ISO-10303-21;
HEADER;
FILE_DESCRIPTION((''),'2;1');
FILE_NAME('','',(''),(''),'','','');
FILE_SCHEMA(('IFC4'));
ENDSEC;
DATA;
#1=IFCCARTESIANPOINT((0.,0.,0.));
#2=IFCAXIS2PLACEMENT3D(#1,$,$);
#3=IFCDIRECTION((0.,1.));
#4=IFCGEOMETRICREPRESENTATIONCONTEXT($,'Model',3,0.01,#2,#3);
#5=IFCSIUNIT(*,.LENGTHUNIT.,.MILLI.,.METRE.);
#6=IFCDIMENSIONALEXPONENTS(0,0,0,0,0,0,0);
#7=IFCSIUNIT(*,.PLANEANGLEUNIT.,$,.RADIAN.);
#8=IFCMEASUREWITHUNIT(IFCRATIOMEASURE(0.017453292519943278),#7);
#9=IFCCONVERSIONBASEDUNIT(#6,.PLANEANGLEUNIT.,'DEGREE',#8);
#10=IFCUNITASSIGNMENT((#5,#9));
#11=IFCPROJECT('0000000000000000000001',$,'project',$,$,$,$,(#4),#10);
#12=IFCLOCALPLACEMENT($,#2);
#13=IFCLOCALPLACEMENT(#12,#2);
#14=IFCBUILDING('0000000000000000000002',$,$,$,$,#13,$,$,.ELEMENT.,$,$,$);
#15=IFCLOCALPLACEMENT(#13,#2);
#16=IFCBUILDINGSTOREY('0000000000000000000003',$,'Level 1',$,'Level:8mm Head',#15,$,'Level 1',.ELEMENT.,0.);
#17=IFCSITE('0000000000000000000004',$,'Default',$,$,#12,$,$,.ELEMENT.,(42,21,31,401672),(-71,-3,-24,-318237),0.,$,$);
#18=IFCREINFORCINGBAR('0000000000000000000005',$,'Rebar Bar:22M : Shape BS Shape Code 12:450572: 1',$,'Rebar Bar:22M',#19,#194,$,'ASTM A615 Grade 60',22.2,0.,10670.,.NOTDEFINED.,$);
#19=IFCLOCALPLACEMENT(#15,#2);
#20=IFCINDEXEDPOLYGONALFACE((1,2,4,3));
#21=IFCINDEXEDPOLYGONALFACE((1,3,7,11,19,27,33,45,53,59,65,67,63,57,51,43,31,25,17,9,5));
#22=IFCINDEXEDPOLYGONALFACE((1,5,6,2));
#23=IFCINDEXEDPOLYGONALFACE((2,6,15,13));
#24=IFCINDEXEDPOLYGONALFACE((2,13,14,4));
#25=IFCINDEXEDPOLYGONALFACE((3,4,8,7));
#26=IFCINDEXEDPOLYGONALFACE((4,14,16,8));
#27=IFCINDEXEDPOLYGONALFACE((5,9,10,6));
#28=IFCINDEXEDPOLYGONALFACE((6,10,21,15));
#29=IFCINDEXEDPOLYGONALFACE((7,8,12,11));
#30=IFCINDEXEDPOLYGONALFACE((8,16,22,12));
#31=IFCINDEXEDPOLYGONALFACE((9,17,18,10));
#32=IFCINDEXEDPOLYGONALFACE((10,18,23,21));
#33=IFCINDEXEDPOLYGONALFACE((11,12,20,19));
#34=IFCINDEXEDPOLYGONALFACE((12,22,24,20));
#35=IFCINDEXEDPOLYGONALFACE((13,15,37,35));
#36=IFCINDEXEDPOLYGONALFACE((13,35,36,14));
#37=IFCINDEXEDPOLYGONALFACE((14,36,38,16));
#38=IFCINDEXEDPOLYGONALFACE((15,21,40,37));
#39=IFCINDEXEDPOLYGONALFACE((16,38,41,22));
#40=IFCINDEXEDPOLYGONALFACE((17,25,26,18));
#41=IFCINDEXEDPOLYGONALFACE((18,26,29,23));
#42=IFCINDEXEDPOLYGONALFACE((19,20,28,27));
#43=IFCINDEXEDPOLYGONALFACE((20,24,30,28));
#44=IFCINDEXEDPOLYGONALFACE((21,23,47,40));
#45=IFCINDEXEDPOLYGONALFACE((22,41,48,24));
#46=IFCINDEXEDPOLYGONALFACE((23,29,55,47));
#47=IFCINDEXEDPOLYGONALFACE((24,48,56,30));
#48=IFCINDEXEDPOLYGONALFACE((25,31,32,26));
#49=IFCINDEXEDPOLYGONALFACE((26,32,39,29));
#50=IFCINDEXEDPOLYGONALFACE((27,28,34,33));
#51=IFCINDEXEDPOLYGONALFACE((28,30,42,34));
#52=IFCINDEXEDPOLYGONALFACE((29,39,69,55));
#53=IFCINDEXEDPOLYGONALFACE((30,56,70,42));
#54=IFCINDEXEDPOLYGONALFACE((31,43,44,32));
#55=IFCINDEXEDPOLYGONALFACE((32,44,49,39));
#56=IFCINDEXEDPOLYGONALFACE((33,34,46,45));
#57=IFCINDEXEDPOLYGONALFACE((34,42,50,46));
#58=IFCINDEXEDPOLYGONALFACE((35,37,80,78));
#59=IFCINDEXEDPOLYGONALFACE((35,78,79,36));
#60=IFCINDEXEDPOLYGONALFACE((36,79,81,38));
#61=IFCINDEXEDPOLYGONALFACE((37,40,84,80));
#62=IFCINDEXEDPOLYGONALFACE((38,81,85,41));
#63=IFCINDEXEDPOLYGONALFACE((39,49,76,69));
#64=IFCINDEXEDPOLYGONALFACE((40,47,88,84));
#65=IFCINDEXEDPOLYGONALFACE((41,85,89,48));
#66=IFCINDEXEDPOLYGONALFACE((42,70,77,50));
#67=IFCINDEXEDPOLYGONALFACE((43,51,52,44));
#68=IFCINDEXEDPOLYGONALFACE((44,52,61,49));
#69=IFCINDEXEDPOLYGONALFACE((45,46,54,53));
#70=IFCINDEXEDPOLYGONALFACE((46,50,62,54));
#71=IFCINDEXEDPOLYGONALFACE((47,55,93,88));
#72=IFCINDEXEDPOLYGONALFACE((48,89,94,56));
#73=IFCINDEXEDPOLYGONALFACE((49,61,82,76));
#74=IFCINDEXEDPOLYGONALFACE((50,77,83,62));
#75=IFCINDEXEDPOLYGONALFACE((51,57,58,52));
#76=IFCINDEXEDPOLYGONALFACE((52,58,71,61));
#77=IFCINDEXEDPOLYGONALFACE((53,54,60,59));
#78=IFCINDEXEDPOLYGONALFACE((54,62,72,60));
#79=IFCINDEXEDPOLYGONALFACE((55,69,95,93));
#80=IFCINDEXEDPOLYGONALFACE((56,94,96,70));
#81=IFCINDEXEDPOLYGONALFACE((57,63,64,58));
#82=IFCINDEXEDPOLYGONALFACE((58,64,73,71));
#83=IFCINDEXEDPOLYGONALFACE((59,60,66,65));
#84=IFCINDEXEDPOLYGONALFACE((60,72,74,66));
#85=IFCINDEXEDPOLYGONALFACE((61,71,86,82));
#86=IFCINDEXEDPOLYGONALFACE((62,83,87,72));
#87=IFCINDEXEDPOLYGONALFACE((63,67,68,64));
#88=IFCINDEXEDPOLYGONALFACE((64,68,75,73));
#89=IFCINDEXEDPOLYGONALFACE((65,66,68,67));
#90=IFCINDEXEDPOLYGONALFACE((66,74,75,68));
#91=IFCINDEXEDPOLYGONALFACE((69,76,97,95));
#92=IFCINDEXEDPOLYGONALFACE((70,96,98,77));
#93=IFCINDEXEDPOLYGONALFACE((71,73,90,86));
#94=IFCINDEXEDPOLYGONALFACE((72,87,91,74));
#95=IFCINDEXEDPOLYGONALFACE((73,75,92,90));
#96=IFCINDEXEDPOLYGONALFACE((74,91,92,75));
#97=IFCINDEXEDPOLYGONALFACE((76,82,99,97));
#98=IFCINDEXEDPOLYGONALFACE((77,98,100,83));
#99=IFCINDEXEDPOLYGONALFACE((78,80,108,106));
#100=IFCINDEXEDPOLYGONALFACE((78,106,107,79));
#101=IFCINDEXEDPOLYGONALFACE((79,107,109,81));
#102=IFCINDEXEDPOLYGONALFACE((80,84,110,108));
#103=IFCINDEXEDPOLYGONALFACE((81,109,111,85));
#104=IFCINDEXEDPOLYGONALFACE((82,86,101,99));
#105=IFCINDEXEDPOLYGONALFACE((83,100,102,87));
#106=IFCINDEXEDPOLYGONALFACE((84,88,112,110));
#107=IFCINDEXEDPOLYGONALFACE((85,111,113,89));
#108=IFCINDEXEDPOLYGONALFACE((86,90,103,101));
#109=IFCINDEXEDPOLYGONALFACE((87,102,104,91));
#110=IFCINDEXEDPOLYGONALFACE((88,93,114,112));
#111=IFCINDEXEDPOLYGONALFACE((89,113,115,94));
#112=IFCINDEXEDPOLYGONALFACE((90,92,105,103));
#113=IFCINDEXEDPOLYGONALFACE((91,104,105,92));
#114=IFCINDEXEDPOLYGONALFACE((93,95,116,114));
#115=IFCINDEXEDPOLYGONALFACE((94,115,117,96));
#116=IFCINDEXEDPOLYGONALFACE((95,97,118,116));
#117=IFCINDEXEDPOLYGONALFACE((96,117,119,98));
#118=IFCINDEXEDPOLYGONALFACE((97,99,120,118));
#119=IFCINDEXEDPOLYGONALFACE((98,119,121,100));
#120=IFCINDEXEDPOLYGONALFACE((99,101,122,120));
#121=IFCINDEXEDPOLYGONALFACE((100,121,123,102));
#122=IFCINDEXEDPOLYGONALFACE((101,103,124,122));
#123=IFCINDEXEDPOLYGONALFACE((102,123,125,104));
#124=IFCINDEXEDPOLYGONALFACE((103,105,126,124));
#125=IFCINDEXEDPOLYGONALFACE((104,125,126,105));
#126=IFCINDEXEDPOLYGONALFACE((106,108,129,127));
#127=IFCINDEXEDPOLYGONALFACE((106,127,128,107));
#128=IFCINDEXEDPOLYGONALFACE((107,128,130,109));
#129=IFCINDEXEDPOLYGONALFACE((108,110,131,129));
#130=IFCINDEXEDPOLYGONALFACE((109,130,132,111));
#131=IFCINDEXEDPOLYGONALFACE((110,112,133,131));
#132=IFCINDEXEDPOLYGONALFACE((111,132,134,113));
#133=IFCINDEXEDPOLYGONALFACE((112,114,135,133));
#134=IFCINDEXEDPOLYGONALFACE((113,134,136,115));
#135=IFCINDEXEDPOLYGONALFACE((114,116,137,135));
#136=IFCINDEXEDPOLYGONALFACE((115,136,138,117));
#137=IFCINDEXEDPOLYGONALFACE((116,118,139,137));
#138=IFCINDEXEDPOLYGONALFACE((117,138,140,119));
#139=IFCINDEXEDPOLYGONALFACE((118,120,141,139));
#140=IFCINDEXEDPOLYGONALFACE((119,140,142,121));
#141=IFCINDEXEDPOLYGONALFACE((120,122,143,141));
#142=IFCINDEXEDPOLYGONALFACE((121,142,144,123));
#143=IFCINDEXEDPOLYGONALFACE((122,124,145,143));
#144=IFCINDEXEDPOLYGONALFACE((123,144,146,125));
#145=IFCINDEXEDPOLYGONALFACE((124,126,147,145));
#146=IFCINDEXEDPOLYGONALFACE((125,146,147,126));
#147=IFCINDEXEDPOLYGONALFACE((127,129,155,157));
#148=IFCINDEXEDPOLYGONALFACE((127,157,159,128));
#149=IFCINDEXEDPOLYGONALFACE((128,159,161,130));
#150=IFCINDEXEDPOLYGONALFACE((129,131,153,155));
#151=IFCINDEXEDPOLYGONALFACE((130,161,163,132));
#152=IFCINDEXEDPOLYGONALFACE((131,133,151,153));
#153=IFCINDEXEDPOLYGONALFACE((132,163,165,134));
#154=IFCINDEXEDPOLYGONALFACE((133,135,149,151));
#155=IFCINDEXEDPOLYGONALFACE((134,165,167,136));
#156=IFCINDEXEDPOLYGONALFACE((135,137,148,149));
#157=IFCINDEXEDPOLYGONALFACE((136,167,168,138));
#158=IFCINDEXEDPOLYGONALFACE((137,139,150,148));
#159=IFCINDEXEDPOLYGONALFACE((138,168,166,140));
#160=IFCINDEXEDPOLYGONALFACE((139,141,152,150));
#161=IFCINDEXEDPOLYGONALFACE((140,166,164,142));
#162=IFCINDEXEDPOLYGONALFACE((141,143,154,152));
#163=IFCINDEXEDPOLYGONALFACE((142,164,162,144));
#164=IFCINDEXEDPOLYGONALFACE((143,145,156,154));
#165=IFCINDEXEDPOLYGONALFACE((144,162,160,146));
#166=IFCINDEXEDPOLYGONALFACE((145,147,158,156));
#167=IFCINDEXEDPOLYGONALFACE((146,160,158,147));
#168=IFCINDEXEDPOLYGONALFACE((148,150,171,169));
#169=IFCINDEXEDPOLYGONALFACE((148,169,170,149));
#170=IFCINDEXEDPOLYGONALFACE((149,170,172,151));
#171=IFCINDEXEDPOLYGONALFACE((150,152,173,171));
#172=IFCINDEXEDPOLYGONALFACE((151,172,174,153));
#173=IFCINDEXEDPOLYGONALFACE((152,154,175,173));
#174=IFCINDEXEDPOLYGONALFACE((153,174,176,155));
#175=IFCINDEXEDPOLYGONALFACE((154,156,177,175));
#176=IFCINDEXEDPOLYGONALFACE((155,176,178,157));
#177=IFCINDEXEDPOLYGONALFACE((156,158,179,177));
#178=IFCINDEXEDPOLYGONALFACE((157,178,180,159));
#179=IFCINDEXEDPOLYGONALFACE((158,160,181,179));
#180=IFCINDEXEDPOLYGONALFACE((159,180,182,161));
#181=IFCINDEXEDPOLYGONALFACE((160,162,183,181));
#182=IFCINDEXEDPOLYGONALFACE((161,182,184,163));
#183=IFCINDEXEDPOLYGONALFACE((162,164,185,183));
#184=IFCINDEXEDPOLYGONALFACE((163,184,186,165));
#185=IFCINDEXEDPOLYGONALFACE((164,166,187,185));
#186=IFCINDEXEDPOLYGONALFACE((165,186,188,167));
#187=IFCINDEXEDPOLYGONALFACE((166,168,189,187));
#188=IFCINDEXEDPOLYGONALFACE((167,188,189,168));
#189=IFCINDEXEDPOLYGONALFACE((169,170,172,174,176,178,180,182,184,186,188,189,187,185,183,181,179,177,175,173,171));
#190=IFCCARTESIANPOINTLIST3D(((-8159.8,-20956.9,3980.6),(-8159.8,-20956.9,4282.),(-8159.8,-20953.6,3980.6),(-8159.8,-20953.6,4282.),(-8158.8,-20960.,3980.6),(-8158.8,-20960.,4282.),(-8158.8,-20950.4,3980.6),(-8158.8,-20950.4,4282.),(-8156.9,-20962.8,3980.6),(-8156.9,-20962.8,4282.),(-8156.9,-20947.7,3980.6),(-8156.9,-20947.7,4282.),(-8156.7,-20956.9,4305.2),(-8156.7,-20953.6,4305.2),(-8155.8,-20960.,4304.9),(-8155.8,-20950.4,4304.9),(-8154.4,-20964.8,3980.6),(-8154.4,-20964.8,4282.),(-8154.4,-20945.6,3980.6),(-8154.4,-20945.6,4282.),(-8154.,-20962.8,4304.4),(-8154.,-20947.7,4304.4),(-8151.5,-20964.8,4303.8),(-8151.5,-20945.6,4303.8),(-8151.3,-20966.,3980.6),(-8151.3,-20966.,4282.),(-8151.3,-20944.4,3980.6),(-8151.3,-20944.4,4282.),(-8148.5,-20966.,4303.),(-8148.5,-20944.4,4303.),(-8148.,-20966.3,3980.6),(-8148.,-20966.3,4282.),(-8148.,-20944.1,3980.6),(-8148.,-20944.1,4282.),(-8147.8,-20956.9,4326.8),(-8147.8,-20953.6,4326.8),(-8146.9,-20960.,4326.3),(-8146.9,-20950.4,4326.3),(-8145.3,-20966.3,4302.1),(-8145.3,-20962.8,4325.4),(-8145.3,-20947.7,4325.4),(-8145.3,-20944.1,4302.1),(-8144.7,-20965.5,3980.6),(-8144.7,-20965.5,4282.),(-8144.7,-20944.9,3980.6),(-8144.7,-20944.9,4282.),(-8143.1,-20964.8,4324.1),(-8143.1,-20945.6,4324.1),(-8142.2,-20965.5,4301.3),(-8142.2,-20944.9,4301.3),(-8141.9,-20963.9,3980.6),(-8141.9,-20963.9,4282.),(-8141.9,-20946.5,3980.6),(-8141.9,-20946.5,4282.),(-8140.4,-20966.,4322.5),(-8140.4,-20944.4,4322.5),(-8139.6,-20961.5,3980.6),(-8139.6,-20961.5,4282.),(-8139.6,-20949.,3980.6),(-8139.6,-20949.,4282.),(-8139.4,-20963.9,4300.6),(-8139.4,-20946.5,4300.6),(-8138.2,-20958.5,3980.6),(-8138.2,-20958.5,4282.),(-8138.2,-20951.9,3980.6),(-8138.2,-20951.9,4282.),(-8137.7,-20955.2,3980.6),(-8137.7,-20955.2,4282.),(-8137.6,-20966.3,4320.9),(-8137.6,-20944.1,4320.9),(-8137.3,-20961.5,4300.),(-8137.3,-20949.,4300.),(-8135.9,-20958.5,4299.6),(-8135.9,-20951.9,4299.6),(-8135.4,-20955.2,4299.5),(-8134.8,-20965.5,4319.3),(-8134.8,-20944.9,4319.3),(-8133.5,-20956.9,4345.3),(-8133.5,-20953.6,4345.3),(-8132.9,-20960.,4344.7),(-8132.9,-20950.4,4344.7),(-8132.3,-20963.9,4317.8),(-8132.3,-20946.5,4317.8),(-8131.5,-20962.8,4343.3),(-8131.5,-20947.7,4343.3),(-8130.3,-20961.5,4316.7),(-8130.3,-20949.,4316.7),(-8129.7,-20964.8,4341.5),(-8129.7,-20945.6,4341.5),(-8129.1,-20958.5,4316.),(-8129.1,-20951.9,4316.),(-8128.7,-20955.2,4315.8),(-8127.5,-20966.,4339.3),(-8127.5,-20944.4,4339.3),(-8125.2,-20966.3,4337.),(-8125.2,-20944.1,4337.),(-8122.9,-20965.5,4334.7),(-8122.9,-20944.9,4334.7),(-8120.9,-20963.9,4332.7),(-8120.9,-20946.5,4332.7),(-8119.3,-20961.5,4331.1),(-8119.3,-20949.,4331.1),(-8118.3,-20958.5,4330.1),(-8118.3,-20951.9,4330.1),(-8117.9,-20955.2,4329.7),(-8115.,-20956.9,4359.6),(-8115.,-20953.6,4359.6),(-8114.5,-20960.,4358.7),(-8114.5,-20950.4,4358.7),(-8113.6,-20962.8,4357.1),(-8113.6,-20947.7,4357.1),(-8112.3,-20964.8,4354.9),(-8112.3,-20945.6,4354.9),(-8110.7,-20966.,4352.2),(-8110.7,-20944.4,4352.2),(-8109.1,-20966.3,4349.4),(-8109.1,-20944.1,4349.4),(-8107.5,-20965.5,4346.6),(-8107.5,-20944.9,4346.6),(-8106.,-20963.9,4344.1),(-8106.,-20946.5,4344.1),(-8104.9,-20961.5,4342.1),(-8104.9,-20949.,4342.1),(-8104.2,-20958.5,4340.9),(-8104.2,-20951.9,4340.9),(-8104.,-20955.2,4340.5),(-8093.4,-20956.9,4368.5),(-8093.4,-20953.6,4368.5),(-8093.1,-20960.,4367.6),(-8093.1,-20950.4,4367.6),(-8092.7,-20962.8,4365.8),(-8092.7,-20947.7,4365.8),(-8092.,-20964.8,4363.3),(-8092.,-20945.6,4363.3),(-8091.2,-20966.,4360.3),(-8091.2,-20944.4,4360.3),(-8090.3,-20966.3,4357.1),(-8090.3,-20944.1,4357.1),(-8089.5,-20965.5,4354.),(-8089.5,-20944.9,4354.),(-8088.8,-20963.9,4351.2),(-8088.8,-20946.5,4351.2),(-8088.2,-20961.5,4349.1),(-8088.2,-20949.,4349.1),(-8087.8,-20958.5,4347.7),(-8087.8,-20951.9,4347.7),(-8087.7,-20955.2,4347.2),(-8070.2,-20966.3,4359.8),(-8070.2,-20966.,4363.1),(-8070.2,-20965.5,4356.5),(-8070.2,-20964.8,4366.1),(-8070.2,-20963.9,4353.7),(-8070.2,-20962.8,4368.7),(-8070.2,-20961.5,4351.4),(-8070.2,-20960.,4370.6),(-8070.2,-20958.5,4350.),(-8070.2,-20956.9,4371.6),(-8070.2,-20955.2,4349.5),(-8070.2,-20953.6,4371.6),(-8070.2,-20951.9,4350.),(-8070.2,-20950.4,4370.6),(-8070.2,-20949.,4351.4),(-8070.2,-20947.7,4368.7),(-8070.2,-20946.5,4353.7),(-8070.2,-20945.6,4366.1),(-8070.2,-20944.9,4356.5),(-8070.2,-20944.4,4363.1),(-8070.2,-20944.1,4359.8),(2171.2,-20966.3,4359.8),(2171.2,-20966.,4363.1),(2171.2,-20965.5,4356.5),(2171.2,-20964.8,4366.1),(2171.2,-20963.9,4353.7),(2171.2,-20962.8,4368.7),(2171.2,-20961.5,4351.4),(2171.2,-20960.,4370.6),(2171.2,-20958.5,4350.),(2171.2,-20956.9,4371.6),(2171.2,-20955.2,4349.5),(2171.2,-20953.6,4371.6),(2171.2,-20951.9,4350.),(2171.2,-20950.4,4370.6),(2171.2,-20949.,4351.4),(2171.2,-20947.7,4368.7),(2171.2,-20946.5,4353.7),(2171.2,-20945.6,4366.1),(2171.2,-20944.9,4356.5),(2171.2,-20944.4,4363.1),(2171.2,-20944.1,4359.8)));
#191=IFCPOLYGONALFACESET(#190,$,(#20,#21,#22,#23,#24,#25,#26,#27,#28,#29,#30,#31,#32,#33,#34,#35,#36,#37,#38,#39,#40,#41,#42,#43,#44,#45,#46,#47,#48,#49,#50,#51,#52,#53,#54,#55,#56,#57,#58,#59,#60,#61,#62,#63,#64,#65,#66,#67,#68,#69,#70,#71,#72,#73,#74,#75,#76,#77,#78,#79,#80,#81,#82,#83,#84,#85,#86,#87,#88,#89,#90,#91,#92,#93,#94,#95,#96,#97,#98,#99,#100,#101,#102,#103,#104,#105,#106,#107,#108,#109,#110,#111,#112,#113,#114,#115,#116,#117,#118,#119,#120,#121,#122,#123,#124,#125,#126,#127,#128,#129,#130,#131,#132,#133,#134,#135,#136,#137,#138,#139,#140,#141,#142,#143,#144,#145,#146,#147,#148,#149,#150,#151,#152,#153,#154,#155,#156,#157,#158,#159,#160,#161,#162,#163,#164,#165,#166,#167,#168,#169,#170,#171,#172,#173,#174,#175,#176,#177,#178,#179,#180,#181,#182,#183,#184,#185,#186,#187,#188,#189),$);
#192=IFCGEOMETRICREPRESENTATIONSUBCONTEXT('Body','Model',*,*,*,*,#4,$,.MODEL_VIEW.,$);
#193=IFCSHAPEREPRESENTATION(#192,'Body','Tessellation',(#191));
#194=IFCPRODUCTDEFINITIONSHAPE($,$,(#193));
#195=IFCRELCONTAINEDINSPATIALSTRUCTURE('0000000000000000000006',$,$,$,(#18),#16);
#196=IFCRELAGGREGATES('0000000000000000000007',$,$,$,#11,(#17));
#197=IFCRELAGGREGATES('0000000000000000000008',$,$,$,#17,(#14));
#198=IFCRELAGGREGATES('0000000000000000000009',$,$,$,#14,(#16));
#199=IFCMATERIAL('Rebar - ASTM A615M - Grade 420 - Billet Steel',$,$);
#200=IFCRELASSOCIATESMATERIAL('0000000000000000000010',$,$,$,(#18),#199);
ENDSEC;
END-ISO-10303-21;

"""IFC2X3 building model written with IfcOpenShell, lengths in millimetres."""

from ifc_helpers import new_model, entity, si_unit, converted_unit, direction, origin, place, context, subcontext, project, spatial, material, element, save


model = new_model("IFC2X3")

# Units and contexts
model_context = context("Model", 3, precision=0.01, world=origin(), true_north=direction((0.0, 1.0)))
body_context = subcontext(model_context, "Body", "Model", "MODEL_VIEW")
ifc_project = project(units=[si_unit("LENGTHUNIT", "METRE", prefix="MILLI"), converted_unit("PLANEANGLEUNIT", "DEGREE", entity("IfcRatioMeasure", 0.017453292519943278), si_unit("PLANEANGLEUNIT", "RADIAN"), dimensions=[0, 0, 0, 0, 0, 0, 0])], contexts=[model_context])

# Site, building, storey
site_placement = place(None, origin())
site = spatial("IfcSite", under=ifc_project, at=site_placement, Name="Default", CompositionType="ELEMENT", RefLatitude=(42, 21, 31, 401672), RefLongitude=(-71, -3, -24, -318237), RefElevation=0.0)
building_placement = place(site_placement, origin())
building = spatial("IfcBuilding", under=site, at=building_placement, CompositionType="ELEMENT")
storey_placement = place(building_placement, origin())
storey = spatial("IfcBuildingStorey", under=building, at=storey_placement, Name="Level 1", ObjectType="Level:8mm Head", LongName="Level 1", CompositionType="ELEMENT", Elevation=0.0)

# Reinforcing bar
ifc_material = material(Name="Rebar - ASTM A615M - Grade 420 - Billet Steel")
reinforcing_bar_1_placement = place(storey_placement, origin())
element("IfcReinforcingBar", 1, at=reinforcing_bar_1_placement, inside=storey, material=ifc_material, Name="Rebar Bar:22M : Shape BS Shape Code 12:450572: 1", SteelGrade="ASTM A615 Grade 60", ObjectType="Rebar Bar:22M", BarLength=10670.0, BarRole="NOTDEFINED", CrossSectionArea=0.0, NominalDiameter=22.2, context=body_context, shape_type="AdvancedSweptSolid", body=[
    entity("IfcSweptDiskSolid", entity("IfcCompositeCurve", [entity("IfcCompositeCurveSegment", "CONTINUOUS", True, entity("IfcPolyline", [entity("IfcCartesianPoint", [2171.2, -20955.2, 4360.6]), entity("IfcCartesianPoint", [-8070.2, -20955.2, 4360.6])])), entity("IfcCompositeCurveSegment", "CONTINUOUS", True, entity("IfcTrimmedCurve", entity("IfcCircle", entity("IfcAxis2Placement3D", entity("IfcCartesianPoint", [-8070.2, -20955.2, 4282.0]), entity("IfcDirection", [0.0, -1.0, 0.0]), entity("IfcDirection", [-1.0, 0.0, 0.0])), 78.6), [entity("IfcParameterValue", 270.0)], [entity("IfcParameterValue", 360.0)], True, "PARAMETER")), entity("IfcCompositeCurveSegment", "CONTINUOUS", True, entity("IfcPolyline", [entity("IfcCartesianPoint", [-8148.8, -20955.2, 4282.0]), entity("IfcCartesianPoint", [-8148.8, -20955.2, 3980.6])]))], False), 11.1, None, 0.0, 92.0),
])

save(model, "model.ifc")
